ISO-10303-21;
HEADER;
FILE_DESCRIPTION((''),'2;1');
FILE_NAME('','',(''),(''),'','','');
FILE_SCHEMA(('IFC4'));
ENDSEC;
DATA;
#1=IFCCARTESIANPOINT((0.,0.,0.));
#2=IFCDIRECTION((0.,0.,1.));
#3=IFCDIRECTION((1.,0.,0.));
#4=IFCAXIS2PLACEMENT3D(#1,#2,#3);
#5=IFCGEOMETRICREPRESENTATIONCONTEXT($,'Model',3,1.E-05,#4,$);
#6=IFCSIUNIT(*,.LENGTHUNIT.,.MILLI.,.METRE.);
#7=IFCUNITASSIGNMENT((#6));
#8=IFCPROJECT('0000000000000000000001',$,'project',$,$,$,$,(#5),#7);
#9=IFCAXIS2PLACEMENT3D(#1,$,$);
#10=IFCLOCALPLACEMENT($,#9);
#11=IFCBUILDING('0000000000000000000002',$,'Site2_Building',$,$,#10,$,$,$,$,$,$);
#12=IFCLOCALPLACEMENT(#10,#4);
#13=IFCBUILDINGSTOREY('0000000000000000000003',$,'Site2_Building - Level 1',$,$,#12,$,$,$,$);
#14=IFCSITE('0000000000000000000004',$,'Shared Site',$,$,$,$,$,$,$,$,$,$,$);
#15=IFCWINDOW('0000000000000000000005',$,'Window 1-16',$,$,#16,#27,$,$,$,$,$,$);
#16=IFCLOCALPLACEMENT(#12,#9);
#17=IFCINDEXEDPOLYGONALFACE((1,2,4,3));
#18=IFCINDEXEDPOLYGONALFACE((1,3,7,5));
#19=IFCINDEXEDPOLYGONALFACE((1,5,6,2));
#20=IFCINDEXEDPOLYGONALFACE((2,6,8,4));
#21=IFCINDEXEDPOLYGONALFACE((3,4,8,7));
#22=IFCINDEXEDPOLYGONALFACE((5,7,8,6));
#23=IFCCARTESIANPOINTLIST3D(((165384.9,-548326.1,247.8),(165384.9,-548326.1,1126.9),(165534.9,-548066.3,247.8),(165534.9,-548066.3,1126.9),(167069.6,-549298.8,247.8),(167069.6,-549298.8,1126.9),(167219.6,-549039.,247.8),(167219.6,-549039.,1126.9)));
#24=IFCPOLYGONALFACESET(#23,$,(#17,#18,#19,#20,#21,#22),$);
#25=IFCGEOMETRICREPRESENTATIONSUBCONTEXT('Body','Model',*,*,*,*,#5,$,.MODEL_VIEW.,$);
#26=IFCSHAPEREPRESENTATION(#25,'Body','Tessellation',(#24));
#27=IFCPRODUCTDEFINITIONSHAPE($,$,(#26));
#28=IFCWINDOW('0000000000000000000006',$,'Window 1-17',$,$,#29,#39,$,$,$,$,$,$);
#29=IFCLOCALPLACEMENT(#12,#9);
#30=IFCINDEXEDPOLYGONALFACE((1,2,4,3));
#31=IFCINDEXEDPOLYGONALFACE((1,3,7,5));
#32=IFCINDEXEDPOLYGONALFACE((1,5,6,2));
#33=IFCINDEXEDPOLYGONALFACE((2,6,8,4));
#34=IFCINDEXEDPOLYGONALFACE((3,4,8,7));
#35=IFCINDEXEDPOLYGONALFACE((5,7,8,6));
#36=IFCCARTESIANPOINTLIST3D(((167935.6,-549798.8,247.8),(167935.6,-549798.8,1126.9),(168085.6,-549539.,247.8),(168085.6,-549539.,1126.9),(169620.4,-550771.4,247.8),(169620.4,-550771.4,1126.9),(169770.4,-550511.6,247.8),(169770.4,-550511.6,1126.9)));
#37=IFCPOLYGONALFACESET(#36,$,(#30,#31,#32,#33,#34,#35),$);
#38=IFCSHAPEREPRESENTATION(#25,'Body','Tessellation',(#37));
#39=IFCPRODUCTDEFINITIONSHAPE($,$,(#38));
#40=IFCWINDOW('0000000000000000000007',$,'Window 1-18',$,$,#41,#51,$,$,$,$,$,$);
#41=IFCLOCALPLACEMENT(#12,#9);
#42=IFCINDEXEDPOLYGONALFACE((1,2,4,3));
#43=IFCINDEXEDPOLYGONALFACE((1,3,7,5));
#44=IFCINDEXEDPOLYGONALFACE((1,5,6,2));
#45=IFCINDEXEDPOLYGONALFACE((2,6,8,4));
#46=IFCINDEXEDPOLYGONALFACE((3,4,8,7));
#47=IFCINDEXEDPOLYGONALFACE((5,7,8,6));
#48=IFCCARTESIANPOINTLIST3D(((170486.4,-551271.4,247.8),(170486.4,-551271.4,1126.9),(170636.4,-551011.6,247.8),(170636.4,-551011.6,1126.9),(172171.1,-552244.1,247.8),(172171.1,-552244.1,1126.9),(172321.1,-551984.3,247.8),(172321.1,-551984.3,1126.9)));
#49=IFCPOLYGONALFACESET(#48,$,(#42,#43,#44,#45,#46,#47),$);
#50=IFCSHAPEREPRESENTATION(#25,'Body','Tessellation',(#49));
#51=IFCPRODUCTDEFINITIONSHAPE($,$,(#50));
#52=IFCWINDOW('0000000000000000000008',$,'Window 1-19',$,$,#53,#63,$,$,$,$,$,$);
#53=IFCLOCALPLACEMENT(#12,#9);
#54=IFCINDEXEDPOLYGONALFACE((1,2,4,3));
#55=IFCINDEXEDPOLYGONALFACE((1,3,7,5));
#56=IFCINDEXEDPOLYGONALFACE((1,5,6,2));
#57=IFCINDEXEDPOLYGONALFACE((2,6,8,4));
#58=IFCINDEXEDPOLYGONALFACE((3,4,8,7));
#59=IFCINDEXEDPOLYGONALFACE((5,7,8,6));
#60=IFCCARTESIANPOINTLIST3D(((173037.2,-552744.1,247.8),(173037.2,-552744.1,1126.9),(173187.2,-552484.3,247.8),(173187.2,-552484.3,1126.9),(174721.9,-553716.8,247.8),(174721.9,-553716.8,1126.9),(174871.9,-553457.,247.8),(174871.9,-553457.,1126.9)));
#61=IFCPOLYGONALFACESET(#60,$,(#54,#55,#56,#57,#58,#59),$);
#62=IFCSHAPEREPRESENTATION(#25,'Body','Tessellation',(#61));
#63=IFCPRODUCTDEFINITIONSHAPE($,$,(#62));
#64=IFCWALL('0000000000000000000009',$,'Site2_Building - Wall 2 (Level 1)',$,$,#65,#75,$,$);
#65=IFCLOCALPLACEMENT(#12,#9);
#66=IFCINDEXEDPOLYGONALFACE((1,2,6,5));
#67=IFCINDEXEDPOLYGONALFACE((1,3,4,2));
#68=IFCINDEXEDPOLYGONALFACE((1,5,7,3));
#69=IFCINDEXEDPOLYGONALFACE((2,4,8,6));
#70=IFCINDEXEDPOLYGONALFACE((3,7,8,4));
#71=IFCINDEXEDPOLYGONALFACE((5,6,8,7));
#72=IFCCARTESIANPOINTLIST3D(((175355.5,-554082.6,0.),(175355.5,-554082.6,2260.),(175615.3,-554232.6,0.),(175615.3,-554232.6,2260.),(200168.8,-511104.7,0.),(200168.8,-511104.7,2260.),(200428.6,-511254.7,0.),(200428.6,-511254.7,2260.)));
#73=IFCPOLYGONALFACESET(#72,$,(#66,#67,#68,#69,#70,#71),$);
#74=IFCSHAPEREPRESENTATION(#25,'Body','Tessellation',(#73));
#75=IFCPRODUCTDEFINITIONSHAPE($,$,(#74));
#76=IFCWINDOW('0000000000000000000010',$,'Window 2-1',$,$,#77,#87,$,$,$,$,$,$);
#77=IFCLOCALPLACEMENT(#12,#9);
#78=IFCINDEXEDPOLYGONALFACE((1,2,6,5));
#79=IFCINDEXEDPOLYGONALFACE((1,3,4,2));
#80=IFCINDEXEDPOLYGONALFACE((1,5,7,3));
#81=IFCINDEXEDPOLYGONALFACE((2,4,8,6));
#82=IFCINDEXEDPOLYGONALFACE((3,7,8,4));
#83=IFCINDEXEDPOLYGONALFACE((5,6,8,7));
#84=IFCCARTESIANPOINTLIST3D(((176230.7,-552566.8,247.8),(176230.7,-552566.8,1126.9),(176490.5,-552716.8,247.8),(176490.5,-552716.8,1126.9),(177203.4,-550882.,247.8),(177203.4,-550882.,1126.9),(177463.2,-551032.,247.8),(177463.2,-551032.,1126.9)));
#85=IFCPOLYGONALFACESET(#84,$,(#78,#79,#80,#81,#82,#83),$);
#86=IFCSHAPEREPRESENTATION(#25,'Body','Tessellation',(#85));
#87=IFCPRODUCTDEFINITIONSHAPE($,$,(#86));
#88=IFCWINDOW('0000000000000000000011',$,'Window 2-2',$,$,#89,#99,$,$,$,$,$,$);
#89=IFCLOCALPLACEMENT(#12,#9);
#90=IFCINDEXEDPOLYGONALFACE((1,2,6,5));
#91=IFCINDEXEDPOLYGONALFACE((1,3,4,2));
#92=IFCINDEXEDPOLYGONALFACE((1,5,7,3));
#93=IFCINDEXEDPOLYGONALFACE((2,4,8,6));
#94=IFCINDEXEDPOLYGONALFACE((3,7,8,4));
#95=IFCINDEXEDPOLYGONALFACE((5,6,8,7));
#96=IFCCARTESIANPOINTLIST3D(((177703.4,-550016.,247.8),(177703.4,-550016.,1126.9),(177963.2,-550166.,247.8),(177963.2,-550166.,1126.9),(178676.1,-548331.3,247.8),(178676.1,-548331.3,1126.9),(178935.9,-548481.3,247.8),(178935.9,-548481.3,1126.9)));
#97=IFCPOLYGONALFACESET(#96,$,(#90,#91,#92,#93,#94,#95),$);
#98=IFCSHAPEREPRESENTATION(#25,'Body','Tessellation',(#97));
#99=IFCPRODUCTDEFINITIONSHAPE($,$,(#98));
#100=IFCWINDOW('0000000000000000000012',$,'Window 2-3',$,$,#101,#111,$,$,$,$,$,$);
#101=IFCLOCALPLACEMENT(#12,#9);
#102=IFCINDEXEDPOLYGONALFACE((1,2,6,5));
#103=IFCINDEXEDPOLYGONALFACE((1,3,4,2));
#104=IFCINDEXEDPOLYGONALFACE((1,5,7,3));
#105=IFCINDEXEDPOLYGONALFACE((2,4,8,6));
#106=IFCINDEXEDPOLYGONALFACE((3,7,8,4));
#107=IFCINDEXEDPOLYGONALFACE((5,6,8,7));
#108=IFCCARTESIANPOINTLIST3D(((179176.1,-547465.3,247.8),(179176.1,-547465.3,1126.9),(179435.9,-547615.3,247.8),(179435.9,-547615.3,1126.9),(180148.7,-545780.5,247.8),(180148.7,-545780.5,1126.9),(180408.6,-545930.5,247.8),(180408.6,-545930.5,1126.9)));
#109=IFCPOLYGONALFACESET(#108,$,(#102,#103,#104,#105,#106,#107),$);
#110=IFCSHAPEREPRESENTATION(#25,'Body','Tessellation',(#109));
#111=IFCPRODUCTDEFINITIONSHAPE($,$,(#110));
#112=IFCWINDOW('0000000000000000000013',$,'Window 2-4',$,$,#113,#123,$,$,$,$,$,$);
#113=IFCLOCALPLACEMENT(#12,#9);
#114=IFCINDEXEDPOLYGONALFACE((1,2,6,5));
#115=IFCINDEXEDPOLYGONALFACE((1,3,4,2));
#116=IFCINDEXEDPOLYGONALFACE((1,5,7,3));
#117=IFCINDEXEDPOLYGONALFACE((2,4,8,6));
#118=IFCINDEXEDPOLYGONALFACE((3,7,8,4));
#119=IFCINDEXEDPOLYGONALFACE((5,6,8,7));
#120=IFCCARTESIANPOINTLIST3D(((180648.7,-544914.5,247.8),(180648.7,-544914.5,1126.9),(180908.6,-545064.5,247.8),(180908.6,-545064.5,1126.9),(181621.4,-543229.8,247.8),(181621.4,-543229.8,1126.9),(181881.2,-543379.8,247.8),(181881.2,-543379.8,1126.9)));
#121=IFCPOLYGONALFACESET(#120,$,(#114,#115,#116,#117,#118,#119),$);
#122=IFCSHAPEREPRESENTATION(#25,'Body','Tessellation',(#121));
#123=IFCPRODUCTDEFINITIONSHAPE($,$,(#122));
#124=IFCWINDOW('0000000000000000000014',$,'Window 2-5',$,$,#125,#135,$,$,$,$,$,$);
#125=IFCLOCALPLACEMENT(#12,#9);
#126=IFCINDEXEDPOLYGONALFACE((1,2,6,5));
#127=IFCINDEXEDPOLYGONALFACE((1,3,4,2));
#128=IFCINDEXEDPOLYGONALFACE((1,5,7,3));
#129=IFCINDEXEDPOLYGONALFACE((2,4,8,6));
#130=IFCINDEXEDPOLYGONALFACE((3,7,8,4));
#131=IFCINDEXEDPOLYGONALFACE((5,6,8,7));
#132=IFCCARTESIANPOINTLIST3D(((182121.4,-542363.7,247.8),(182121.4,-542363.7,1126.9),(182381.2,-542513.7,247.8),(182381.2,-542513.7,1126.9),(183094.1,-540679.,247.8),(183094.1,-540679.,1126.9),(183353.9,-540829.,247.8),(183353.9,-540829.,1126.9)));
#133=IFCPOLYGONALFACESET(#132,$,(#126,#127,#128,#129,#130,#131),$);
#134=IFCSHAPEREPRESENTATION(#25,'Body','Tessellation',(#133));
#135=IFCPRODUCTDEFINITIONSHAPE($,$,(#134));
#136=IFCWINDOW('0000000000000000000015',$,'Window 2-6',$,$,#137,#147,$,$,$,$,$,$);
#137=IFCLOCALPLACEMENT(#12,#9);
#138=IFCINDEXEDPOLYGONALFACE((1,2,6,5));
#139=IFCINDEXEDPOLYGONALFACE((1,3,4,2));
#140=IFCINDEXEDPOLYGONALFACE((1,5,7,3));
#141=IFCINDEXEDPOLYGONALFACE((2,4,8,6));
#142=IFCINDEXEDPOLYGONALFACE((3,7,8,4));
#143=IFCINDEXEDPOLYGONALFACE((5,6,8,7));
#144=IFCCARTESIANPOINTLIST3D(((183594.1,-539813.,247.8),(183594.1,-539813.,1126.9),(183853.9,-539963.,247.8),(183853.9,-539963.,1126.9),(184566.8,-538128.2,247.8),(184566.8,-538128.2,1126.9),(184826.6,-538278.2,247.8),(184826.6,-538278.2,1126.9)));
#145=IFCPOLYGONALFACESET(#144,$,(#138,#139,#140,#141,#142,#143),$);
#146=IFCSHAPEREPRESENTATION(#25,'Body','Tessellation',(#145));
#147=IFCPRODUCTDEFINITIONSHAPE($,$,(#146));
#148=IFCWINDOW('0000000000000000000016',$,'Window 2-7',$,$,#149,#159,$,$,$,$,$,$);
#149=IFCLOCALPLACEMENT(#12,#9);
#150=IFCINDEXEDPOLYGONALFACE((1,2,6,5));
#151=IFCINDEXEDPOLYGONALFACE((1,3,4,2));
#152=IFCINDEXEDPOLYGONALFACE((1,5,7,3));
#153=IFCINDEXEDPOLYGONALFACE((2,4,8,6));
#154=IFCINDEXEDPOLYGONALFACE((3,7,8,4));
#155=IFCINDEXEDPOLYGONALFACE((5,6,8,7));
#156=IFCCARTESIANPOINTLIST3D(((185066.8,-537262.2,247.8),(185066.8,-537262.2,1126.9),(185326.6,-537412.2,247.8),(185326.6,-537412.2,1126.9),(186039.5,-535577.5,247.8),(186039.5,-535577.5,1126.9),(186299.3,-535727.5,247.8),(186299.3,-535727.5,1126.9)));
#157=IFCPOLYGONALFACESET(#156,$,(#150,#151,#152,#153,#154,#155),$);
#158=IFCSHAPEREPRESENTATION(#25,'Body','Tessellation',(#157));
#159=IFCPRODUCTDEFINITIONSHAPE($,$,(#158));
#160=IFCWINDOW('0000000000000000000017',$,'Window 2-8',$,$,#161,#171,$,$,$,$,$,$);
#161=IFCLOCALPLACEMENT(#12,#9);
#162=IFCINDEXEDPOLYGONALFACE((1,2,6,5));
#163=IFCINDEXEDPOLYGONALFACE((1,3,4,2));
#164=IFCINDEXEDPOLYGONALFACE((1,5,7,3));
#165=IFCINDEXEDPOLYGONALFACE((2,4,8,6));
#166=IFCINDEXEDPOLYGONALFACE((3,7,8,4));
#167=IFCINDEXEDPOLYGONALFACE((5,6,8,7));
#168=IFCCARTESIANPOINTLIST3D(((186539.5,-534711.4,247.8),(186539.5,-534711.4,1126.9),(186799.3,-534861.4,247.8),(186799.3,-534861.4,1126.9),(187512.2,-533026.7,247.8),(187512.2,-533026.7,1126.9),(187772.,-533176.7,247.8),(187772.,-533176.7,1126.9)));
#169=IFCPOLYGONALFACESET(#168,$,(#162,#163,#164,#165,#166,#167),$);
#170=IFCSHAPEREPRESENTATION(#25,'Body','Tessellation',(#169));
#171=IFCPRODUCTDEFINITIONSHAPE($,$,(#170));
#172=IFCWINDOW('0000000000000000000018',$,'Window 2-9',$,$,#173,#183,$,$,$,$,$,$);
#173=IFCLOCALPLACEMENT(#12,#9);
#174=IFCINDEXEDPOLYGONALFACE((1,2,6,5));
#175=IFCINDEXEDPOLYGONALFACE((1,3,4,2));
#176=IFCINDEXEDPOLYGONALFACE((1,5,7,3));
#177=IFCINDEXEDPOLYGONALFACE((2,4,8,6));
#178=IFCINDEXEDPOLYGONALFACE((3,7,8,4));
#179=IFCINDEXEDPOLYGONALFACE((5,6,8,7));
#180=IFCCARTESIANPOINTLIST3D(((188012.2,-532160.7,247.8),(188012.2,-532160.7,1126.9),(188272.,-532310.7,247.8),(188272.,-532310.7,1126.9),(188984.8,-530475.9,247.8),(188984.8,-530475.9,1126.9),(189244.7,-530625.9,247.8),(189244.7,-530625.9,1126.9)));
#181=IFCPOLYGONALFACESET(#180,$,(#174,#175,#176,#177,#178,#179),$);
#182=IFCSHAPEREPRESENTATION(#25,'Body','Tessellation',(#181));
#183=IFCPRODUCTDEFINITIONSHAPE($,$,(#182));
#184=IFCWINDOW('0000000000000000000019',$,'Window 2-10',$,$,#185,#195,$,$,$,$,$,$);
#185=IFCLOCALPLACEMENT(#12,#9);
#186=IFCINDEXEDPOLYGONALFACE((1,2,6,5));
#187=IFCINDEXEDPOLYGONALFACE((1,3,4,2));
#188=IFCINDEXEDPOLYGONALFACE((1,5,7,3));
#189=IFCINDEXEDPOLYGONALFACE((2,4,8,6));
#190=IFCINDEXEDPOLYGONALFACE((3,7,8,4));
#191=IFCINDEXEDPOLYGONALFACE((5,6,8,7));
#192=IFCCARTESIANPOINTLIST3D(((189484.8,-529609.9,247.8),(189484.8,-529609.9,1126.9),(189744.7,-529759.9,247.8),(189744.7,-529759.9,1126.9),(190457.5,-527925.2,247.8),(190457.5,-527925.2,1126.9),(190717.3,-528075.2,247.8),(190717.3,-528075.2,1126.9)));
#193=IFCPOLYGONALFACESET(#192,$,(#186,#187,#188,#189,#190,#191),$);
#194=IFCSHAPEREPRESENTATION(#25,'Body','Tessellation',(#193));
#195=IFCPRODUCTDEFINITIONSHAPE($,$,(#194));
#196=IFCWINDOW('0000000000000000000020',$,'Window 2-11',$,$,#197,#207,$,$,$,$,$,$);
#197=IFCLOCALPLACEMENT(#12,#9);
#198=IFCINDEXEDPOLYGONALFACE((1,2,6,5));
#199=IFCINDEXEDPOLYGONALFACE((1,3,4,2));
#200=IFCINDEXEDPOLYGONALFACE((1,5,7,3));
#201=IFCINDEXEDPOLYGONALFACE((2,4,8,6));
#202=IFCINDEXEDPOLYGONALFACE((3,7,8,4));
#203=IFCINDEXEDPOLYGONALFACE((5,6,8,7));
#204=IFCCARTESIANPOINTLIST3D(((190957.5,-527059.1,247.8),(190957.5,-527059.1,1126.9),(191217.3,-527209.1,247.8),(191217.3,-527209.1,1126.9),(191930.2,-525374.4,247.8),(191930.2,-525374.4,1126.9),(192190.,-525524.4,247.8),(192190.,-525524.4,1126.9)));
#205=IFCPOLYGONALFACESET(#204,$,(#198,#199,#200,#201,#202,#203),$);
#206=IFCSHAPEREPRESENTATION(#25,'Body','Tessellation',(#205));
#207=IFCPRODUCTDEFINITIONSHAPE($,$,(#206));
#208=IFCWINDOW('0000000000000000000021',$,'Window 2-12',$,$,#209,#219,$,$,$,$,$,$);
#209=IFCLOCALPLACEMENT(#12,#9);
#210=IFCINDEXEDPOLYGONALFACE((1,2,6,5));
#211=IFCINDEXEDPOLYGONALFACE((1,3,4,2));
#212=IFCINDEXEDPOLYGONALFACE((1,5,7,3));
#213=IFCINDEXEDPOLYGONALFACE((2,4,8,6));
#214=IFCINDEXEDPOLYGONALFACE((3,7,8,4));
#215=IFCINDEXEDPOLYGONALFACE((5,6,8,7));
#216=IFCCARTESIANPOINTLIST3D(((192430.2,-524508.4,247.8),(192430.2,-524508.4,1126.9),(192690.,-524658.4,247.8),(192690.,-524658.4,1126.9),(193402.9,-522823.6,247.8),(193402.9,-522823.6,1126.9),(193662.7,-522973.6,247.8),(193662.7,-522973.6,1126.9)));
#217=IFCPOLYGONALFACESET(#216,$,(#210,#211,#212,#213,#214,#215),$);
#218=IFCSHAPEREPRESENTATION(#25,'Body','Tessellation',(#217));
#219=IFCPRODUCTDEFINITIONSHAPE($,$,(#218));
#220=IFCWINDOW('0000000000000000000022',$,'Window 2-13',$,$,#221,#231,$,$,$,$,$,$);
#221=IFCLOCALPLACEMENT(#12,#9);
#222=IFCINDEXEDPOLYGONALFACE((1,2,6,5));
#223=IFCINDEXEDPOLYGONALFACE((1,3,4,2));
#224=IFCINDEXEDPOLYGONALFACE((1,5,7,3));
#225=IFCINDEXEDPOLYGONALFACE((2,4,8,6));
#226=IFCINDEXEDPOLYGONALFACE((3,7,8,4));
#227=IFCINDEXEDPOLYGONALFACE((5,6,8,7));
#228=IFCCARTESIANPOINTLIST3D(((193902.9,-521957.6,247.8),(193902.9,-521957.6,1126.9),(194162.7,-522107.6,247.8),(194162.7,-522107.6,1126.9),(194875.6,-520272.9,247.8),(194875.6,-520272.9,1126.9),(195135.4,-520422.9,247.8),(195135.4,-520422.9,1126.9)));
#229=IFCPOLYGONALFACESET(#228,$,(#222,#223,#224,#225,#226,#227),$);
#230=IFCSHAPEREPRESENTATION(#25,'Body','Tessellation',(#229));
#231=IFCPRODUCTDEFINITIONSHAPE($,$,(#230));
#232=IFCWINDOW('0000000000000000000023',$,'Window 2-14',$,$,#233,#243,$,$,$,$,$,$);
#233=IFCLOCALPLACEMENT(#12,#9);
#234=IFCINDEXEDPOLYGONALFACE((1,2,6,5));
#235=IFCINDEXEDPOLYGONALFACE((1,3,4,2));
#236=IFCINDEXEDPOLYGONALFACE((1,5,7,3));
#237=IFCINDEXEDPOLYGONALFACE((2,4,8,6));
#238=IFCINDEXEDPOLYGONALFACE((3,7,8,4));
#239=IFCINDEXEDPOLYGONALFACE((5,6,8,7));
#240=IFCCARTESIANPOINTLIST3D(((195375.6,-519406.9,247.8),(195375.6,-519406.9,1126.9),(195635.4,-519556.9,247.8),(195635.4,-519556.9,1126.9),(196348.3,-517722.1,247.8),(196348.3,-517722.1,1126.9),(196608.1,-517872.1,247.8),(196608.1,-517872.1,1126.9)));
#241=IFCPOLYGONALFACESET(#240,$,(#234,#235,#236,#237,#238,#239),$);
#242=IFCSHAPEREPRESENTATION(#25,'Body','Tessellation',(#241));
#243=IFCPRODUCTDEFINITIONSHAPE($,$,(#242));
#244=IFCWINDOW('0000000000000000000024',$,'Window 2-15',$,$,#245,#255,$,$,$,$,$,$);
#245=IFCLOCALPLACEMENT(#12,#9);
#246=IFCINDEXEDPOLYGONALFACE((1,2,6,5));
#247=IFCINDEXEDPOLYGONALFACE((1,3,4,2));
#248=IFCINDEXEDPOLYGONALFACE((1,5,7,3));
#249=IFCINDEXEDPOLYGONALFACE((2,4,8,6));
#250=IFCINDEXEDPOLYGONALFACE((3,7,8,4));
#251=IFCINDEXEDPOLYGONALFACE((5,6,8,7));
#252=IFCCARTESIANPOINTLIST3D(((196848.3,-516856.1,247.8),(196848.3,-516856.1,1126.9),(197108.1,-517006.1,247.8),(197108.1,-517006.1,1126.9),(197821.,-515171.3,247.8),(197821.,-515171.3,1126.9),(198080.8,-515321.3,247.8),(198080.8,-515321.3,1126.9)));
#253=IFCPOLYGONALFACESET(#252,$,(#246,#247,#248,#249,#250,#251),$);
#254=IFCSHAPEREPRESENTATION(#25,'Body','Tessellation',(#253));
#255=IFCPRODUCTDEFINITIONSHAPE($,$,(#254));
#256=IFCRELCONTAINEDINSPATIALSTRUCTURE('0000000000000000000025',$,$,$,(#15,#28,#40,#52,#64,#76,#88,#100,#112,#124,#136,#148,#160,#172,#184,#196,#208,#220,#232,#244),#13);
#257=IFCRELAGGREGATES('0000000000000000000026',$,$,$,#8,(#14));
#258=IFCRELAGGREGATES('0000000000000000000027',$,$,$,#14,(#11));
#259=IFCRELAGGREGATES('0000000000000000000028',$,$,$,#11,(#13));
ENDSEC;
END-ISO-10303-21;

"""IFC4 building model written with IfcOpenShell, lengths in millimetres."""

from ifc_helpers import new_model, si_unit, frame, origin, origin_with_axes, place, context, subcontext, project, spatial, indexed_curve, outline, extrude, element, save


model = new_model("IFC4")

# Units and contexts
model_context = context("Model", 3, precision=1e-05, world=origin_with_axes())
body_context = subcontext(model_context, "Body", "Model", "MODEL_VIEW")
ifc_project = project(units=[si_unit("LENGTHUNIT", "METRE", prefix="MILLI")], contexts=[model_context])

# Site, building, storey
site = spatial("IfcSite", under=ifc_project, Name="Shared Site")
building_placement = place(None, origin())
building = spatial("IfcBuilding", under=site, at=building_placement, Name="Site2_Building")
storey_placement = place(building_placement, origin_with_axes())
storey = spatial("IfcBuildingStorey", under=building, at=storey_placement, Name="Site2_Building - Level 1")

# Windows
for number, where, z_axis, x_axis, name in (
    (1, (165384.9, -548326.1, 247.8), (0.0, 0.0, 1.0), (0.866025, -0.5, 0.0), "Window 1-16"),
    (2, (167935.6, -549798.8, 247.8), (0.0, 0.0, 1.0), (0.866025, -0.5, 0.0), "Window 1-17"),
    (3, (170486.4, -551271.4, 247.8), (0.0, 0.0, 1.0), (0.866025, -0.5, 0.0), "Window 1-18"),
    (4, (173037.2, -552744.1, 247.8), (0.0, 0.0, 1.0), (0.866025, -0.5, 0.0), "Window 1-19"),
):
    element("IfcWindow", number, at=place(storey_placement, frame(where, z_axis=z_axis, x_axis=x_axis)), inside=storey, Name=name, context=body_context, shape_type="SweptSolid", body=[
        extrude(outline(indexed_curve([(0.0, 0.0), (0.0, 300.0), (1945.4, 300.0), (1945.4, 0.0), (0.0, 0.0)], self_intersect=False)), origin_with_axes(), (0.0, 0.0, 1.0), 879.1),
    ])

# Wall
wall_1_placement = place(storey_placement, frame((175615.3, -554232.6, 0.0), z_axis=(0.0, 0.0, 1.0), x_axis=(0.5, 0.866025, 0.0)))
element("IfcWall", 5, at=wall_1_placement, inside=storey, Name="Site2_Building - Wall 2 (Level 1)", context=body_context, shape_type="SweptSolid", body=[
    extrude(outline(indexed_curve([(0.0, 0.0), (0.0, 300.0), (49626.6, 300.0), (49626.6, 0.0), (0.0, 0.0)], self_intersect=False)), origin_with_axes(), (0.0, 0.0, 1.0), 2260.0),
])

# Windows
for number, where, z_axis, x_axis, name in (
    (6, (176490.5, -552716.8, 247.8), (0.0, 0.0, 1.0), (0.5, 0.866025, 0.0), "Window 2-1"),
    (7, (177963.2, -550166.0, 247.8), (0.0, 0.0, 1.0), (0.5, 0.866025, 0.0), "Window 2-2"),
    (8, (179435.9, -547615.3, 247.8), (0.0, 0.0, 1.0), (0.5, 0.866025, 0.0), "Window 2-3"),
    (9, (180908.6, -545064.5, 247.8), (0.0, 0.0, 1.0), (0.5, 0.866025, 0.0), "Window 2-4"),
    (10, (182381.2, -542513.7, 247.8), (0.0, 0.0, 1.0), (0.5, 0.866025, 0.0), "Window 2-5"),
    (11, (183853.9, -539963.0, 247.8), (0.0, 0.0, 1.0), (0.5, 0.866025, 0.0), "Window 2-6"),
    (12, (185326.6, -537412.2, 247.8), (0.0, 0.0, 1.0), (0.5, 0.866025, 0.0), "Window 2-7"),
    (13, (186799.3, -534861.4, 247.8), (0.0, 0.0, 1.0), (0.5, 0.866025, 0.0), "Window 2-8"),
    (14, (188272.0, -532310.7, 247.8), (0.0, 0.0, 1.0), (0.5, 0.866025, 0.0), "Window 2-9"),
    (15, (189744.7, -529759.9, 247.8), (0.0, 0.0, 1.0), (0.5, 0.866025, 0.0), "Window 2-10"),
    (16, (191217.3, -527209.1, 247.8), (0.0, 0.0, 1.0), (0.5, 0.866025, 0.0), "Window 2-11"),
    (17, (192690.0, -524658.4, 247.8), (0.0, 0.0, 1.0), (0.5, 0.866025, 0.0), "Window 2-12"),
    (18, (194162.7, -522107.6, 247.8), (0.0, 0.0, 1.0), (0.5, 0.866025, 0.0), "Window 2-13"),
    (19, (195635.4, -519556.9, 247.8), (0.0, 0.0, 1.0), (0.5, 0.866025, 0.0), "Window 2-14"),
    (20, (197108.1, -517006.1, 247.8), (0.0, 0.0, 1.0), (0.5, 0.866025, 0.0), "Window 2-15"),
):
    element("IfcWindow", number, at=place(storey_placement, frame(where, z_axis=z_axis, x_axis=x_axis)), inside=storey, Name=name, context=body_context, shape_type="SweptSolid", body=[
        extrude(outline(indexed_curve([(0.0, 0.0), (0.0, 300.0), (1945.4, 300.0), (1945.4, 0.0), (0.0, 0.0)], self_intersect=False)), origin_with_axes(), (0.0, 0.0, 1.0), 879.1),
    ])

save(model, "model.ifc")
